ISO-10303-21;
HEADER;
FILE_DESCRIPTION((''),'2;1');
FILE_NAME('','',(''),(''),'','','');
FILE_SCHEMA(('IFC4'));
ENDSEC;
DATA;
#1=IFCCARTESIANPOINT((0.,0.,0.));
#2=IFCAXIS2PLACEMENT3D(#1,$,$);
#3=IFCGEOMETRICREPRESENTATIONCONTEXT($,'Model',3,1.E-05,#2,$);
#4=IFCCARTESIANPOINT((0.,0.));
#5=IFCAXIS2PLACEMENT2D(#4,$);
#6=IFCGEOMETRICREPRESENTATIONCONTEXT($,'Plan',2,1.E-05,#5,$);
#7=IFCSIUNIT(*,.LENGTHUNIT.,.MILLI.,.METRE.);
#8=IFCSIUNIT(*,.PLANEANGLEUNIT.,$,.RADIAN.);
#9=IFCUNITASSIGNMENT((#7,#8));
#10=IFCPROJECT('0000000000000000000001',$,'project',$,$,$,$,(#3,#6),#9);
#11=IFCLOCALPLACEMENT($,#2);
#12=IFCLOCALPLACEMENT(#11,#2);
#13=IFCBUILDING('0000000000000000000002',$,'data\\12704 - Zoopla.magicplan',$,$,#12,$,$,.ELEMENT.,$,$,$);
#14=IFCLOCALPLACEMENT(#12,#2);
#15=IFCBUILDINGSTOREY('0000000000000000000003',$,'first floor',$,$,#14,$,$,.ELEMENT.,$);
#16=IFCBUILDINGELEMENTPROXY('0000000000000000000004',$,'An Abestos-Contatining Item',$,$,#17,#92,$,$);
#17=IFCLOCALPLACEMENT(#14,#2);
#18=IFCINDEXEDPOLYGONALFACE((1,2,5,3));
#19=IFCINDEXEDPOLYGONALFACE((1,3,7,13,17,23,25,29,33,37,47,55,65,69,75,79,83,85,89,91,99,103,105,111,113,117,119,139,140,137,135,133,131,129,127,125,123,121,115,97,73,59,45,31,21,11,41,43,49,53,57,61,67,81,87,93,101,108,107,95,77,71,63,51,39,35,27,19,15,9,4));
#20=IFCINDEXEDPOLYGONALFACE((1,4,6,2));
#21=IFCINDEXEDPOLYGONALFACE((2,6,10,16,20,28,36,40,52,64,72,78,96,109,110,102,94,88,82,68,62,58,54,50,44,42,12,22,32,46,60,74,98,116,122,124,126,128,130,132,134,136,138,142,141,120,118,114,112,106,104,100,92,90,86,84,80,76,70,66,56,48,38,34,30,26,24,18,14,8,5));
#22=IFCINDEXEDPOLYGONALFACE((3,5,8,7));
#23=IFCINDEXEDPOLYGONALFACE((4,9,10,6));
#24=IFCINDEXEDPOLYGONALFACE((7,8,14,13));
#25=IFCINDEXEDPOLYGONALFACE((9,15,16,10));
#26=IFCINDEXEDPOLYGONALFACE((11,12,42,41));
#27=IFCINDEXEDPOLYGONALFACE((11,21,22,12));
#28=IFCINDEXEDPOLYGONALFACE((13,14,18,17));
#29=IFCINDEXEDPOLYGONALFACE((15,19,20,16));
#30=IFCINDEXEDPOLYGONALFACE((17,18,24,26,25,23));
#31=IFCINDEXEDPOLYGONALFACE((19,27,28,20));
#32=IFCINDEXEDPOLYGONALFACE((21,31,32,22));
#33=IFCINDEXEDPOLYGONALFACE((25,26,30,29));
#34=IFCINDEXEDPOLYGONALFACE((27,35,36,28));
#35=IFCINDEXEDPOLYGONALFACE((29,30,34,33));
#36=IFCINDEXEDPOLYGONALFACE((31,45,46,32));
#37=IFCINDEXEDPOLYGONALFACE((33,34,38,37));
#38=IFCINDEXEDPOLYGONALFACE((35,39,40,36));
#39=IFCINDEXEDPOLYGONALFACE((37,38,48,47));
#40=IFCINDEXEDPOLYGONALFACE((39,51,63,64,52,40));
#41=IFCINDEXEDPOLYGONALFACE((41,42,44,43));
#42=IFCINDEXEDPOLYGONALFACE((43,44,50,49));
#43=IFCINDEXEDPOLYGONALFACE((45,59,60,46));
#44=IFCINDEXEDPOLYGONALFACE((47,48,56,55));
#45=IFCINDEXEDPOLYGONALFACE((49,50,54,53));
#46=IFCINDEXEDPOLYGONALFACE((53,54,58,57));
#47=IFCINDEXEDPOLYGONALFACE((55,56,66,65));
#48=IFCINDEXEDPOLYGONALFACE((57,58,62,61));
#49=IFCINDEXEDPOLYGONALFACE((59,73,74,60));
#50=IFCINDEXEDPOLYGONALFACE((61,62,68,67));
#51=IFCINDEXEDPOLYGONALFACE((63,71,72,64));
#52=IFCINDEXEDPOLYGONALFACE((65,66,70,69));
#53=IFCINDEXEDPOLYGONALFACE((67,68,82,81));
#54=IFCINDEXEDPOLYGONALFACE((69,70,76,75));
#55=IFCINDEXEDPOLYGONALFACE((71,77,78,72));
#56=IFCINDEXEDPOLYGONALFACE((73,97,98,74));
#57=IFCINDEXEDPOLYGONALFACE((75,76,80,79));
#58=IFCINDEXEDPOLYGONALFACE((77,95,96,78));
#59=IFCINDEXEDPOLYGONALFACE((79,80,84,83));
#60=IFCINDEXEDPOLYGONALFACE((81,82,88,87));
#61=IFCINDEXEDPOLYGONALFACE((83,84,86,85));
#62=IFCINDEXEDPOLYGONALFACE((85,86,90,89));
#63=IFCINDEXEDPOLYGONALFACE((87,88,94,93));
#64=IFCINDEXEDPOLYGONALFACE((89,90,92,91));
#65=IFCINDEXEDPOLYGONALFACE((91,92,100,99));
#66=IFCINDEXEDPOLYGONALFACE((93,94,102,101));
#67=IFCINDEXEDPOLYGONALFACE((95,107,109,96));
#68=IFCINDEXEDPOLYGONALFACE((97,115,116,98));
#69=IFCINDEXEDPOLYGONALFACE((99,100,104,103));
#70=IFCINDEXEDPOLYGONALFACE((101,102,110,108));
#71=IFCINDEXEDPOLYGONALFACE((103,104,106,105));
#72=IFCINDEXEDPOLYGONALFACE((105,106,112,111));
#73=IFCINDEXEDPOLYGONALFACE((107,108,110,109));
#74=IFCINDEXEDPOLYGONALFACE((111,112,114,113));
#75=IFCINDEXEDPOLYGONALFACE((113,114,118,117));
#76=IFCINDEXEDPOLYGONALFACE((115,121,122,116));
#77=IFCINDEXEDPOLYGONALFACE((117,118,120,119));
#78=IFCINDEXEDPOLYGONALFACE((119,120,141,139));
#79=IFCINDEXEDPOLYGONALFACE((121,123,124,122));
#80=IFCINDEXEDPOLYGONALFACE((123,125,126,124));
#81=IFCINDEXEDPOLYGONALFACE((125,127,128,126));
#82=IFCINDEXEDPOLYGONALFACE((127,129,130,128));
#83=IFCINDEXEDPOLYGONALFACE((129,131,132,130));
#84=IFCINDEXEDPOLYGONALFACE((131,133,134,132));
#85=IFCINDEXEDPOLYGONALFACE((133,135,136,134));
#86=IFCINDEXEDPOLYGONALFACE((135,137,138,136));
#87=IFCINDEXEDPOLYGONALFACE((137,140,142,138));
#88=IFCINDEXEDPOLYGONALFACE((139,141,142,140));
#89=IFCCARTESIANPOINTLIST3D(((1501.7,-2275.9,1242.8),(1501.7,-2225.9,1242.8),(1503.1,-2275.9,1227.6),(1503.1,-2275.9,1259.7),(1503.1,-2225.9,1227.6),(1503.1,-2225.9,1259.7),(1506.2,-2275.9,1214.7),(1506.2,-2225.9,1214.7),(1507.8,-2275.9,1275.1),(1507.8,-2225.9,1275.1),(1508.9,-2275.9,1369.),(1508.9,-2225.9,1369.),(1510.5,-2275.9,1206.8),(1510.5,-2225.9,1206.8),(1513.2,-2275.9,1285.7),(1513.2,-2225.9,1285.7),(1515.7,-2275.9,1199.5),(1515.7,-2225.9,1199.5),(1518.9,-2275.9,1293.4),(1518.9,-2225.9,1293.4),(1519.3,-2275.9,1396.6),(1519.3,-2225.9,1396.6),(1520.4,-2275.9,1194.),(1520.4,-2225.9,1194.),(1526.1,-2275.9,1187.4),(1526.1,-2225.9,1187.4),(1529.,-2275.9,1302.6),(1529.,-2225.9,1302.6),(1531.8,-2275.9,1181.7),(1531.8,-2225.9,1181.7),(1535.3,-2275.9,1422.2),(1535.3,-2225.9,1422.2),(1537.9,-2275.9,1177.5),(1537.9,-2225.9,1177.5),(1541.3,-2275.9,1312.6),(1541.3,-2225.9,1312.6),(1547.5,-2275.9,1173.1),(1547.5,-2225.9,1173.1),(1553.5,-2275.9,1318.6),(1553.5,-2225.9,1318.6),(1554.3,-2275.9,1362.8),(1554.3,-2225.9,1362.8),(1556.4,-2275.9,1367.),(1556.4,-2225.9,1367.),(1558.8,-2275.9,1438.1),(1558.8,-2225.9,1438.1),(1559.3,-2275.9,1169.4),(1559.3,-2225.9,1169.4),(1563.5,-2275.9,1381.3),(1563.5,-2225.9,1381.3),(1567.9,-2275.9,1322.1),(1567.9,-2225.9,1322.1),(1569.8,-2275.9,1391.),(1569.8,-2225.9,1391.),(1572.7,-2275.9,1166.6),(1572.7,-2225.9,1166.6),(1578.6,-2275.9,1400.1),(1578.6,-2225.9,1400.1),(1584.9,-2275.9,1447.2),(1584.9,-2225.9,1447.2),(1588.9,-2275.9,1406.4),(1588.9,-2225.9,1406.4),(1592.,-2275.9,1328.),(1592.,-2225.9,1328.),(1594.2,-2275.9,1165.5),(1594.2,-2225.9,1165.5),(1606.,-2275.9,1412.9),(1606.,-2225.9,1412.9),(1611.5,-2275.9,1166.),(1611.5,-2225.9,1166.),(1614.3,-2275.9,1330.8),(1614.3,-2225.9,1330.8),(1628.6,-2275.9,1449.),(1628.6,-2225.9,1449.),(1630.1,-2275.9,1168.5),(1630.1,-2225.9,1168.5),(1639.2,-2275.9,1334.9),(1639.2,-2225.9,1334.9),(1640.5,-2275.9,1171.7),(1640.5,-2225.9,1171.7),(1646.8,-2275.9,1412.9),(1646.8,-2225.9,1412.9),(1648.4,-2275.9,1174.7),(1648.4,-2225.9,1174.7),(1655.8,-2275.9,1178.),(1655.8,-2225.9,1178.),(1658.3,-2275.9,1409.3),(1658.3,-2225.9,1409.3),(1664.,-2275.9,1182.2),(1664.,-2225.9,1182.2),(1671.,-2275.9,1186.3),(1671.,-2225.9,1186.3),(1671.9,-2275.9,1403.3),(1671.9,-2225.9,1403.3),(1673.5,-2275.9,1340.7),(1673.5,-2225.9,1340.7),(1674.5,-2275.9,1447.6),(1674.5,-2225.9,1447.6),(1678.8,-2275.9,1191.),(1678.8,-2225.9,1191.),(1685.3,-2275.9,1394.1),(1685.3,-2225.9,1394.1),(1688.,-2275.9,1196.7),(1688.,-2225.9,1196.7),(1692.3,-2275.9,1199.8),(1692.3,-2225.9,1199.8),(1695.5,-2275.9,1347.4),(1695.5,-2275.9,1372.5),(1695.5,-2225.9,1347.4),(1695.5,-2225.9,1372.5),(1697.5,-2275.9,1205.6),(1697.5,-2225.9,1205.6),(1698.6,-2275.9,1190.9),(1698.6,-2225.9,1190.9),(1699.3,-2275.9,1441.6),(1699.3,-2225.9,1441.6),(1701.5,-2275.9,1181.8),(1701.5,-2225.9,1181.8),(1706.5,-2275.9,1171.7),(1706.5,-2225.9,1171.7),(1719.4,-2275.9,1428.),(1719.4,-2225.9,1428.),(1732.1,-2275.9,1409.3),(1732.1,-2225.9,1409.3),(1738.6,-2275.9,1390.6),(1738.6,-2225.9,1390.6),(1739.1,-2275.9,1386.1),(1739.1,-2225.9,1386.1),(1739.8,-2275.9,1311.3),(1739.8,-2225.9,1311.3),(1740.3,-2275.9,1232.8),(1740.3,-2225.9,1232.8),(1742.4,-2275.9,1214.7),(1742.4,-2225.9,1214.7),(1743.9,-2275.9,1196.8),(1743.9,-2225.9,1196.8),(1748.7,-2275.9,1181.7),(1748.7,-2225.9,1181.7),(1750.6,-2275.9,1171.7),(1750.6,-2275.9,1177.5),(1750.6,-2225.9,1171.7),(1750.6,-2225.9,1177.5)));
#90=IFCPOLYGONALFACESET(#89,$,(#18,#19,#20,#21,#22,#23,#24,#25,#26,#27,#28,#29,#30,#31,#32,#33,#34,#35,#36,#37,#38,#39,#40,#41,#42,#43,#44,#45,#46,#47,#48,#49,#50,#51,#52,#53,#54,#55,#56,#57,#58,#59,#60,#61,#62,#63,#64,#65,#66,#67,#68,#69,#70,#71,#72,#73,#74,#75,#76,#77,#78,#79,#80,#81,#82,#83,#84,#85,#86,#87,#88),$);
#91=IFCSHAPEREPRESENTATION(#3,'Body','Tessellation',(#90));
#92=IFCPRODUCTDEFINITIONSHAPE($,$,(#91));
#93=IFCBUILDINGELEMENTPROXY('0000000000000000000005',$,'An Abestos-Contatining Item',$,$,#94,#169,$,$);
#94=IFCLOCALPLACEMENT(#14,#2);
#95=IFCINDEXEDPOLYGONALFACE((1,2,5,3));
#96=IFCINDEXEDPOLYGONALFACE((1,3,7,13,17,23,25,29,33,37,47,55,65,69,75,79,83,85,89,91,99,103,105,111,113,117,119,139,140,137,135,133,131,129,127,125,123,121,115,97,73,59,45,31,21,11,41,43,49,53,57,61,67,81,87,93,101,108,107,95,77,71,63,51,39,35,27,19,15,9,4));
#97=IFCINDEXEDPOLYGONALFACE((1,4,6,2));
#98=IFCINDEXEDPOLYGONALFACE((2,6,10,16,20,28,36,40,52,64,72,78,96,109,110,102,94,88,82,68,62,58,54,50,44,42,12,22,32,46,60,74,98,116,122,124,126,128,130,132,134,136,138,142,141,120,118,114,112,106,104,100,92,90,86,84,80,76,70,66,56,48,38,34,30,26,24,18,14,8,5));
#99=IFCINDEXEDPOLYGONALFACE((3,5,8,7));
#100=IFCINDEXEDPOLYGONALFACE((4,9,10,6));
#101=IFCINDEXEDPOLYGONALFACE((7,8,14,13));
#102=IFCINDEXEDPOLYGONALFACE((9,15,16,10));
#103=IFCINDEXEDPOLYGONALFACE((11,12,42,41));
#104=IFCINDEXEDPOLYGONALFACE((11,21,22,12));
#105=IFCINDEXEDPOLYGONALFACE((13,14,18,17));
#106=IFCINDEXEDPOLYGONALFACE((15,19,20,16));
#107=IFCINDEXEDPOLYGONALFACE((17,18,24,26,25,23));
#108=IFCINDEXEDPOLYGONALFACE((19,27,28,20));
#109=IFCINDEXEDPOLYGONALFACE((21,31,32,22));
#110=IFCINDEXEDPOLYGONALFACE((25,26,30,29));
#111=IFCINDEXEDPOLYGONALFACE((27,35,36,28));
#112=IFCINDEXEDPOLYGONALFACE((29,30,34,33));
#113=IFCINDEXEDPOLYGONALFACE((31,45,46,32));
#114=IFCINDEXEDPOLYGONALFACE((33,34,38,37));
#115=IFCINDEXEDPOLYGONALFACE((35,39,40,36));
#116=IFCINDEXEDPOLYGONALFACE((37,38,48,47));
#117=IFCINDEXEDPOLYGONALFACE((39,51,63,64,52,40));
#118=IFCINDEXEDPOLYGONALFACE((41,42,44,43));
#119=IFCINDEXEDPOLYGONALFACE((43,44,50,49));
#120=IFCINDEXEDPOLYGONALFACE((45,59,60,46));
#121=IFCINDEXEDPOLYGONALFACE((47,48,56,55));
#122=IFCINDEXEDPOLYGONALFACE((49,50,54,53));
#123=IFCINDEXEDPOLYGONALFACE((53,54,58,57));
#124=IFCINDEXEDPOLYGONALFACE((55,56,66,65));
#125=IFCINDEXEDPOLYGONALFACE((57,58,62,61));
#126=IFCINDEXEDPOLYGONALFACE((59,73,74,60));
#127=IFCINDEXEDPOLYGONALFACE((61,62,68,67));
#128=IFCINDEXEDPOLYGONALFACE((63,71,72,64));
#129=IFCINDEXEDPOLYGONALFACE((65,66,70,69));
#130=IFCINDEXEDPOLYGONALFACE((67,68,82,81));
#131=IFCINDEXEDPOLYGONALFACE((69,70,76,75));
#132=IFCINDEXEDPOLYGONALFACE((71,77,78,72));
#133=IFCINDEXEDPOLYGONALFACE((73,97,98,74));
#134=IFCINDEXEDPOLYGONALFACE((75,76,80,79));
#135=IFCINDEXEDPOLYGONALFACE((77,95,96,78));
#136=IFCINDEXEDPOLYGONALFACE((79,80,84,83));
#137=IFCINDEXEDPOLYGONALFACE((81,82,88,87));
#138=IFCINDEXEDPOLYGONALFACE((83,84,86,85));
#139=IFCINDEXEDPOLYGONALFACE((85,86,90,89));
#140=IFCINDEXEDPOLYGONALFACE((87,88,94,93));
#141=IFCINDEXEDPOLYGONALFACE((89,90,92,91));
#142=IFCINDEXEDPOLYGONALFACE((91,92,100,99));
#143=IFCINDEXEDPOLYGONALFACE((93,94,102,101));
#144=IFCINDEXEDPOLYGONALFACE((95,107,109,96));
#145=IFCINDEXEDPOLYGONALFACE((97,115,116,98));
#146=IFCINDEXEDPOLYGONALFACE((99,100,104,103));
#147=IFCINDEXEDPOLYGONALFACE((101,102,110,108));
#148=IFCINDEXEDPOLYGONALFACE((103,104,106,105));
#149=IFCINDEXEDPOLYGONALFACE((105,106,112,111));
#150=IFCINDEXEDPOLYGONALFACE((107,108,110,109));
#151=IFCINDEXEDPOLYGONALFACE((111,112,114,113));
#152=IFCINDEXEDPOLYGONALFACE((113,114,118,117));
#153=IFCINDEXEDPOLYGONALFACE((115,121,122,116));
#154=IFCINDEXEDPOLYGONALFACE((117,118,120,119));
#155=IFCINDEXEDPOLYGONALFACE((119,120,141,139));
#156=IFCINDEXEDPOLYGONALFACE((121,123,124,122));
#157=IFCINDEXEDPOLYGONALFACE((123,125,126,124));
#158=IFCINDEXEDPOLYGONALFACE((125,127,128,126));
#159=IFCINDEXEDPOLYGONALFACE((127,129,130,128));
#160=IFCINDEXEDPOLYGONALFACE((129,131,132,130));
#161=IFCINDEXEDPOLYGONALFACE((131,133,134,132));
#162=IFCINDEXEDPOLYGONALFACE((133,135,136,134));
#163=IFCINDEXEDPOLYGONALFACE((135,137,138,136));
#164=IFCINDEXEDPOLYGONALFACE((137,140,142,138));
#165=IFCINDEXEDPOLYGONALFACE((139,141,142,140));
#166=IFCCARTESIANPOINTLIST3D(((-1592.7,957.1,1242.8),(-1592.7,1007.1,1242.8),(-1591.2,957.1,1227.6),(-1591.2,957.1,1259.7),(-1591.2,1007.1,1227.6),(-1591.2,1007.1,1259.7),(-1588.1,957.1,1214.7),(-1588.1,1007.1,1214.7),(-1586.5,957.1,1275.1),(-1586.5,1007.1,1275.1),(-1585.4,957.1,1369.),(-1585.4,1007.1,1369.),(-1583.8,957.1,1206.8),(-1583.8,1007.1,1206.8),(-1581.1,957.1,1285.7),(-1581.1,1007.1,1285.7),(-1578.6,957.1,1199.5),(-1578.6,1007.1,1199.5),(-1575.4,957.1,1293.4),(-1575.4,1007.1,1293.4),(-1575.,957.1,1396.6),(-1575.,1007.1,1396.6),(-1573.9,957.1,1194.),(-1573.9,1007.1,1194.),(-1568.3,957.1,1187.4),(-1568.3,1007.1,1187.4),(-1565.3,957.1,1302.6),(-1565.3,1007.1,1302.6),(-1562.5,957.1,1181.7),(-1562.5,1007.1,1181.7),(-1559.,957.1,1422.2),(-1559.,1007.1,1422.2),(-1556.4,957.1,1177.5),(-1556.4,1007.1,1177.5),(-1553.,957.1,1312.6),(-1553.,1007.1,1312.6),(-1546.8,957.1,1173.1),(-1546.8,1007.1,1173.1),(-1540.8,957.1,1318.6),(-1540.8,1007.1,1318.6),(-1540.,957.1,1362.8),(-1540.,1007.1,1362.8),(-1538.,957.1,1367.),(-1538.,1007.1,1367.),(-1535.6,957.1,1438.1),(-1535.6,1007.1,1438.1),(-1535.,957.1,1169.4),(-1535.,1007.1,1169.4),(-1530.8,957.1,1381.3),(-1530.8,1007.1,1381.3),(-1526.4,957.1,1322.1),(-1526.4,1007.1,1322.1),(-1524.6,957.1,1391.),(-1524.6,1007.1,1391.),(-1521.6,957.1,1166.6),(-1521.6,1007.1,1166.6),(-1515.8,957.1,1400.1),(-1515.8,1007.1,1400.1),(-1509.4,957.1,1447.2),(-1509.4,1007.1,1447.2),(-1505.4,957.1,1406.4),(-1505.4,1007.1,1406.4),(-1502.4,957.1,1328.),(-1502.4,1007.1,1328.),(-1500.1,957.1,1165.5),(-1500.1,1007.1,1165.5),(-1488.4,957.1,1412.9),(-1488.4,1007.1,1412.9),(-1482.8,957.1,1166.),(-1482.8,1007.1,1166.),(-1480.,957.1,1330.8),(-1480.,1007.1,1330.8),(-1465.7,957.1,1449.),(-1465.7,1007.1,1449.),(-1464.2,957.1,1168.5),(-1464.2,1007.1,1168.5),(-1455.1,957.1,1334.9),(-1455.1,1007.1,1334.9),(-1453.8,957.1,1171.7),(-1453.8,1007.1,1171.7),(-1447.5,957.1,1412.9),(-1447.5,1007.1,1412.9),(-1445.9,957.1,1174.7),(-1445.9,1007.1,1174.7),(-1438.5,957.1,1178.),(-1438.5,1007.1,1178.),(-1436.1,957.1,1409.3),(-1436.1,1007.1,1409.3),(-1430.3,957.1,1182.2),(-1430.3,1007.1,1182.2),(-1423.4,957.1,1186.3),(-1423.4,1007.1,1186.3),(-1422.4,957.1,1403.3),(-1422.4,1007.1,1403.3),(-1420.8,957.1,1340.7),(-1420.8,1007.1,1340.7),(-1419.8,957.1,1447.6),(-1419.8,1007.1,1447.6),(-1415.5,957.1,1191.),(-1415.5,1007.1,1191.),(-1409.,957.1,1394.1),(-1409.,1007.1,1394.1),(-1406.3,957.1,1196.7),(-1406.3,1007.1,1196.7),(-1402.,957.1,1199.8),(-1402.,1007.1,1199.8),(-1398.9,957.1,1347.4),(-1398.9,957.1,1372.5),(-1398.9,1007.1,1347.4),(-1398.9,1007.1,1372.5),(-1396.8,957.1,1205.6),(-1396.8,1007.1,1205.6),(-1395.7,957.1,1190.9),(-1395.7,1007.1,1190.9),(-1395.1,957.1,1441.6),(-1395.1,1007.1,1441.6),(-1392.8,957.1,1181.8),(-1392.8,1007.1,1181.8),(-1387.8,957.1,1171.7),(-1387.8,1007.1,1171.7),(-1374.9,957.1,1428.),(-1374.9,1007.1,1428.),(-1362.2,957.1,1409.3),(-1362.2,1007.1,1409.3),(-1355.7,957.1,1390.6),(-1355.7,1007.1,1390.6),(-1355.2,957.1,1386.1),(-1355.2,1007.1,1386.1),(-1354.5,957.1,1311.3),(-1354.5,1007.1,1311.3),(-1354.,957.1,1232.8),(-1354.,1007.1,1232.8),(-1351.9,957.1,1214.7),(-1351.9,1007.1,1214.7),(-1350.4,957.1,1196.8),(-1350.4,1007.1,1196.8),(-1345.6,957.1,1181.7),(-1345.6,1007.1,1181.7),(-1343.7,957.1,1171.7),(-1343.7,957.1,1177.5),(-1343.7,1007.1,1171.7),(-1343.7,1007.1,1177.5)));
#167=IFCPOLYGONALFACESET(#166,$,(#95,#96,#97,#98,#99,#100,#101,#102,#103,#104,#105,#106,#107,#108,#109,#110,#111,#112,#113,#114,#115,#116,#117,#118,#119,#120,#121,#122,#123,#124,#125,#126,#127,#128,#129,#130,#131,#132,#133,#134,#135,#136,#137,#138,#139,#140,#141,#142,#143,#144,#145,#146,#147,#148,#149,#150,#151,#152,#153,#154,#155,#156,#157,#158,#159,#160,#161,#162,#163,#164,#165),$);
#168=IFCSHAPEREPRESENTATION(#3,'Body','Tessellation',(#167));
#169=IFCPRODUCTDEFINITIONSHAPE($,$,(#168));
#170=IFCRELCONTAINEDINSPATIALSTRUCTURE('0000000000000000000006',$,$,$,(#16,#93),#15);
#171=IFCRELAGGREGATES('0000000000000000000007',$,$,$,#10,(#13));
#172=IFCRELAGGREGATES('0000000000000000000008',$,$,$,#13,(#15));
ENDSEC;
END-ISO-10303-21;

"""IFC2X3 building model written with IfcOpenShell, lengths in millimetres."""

from ifc_helpers import new_model, si_unit, frame, origin, origin_2d, place, context, project, spatial, polyline, outline, extrude, element, save


model = new_model("IFC2X3")

# Units and contexts
model_context = context("Model", 3, precision=1e-05, world=origin())
plan_context = context("Plan", 2, precision=1e-05, world=origin_2d())
ifc_project = project(units=[si_unit("LENGTHUNIT", "METRE", prefix="MILLI"), si_unit("PLANEANGLEUNIT", "RADIAN")], contexts=[model_context, plan_context])

# Building, storey
placement_1 = place(None, origin())
building_placement = place(placement_1, origin())
building = spatial("IfcBuilding", under=ifc_project, at=building_placement, Name="data\\12704 - Zoopla.magicplan", CompositionType="ELEMENT")
storey_placement = place(building_placement, origin())
storey = spatial("IfcBuildingStorey", under=building, at=storey_placement, Name="first floor", CompositionType="ELEMENT")

# Building element proxies
placement_2 = place(None, frame((3984.0, 1316.8, 0.0)))
proxy_1_placement = place(placement_2, frame((-2483.4, -3542.6, 1165.0)))
element("IfcBuildingElementProxy", 1, at=proxy_1_placement, inside=storey, Name="An Abestos-Contatining Item", context=model_context, shape_type="SurfaceModel", body=[
    extrude(outline(polyline([(239.2, 0.0, 146.3), (239.7, 0.0, 67.8), (241.8, 0.0, 49.7), (243.3, 0.0, 31.9), (248.1, 0.0, 16.7), (250.0, 0.0, 12.5), (250.0, 0.0, 6.7), (205.8, 0.0, 6.7), (200.9, 0.0, 16.8), (197.9, 0.0, 25.9), (196.9, 0.0, 40.6), (191.6, 0.0, 34.8), (187.3, 0.0, 31.7), (178.2, 0.0, 26.0), (170.3, 0.0, 21.3), (163.4, 0.0, 17.2), (155.2, 0.0, 13.0), (147.8, 0.0, 9.7), (139.9, 0.0, 6.7), (129.5, 0.0, 3.5), (110.9, 0.0, 1.0), (93.6, 0.0, 0.5), (72.1, 0.0, 1.6), (58.6, 0.0, 4.4), (46.9, 0.0, 8.1), (37.3, 0.0, 12.5), (31.2, 0.0, 16.7), (25.4, 0.0, 22.4), (19.8, 0.0, 29.0), (15.1, 0.0, 34.5), (9.9, 0.0, 41.9), (5.5, 0.0, 49.7), (2.5, 0.0, 62.6), (1.0, 0.0, 77.8), (2.5, 0.0, 94.7), (7.2, 0.0, 110.1), (12.6, 0.0, 120.7), (18.2, 0.0, 128.4), (28.4, 0.0, 137.6), (40.7, 0.0, 147.6), (52.9, 0.0, 153.6), (67.3, 0.0, 157.1), (91.3, 0.0, 163.0), (113.7, 0.0, 165.8), (138.6, 0.0, 169.9), (172.9, 0.0, 175.7), (194.8, 0.0, 182.4), (194.8, 0.0, 207.5), (184.7, 0.0, 229.1), (171.3, 0.0, 238.3), (157.6, 0.0, 244.3), (146.2, 0.0, 247.9), (105.3, 0.0, 247.9), (88.3, 0.0, 241.4), (77.9, 0.0, 235.1), (69.1, 0.0, 226.0), (62.9, 0.0, 216.3), (55.7, 0.0, 202.0), (53.6, 0.0, 197.8), (8.2, 0.0, 204.0), (18.7, 0.0, 231.7), (34.6, 0.0, 257.2), (58.1, 0.0, 273.1), (84.2, 0.0, 282.2), (128.0, 0.0, 284.0), (173.9, 0.0, 282.6), (198.6, 0.0, 276.6), (218.8, 0.0, 263.1), (231.4, 0.0, 244.3), (238.0, 0.0, 225.6), (238.5, 0.0, 221.1)]), holes=[polyline([(193.0, 0.0, 144.2), (193.0, 0.0, 117.7), (190.5, 0.0, 97.8), (183.8, 0.0, 80.4), (174.2, 0.0, 64.5), (165.3, 0.0, 54.4), (152.5, 0.0, 47.3), (138.0, 0.0, 41.5), (124.6, 0.0, 37.8), (85.5, 0.0, 37.8), (75.0, 0.0, 41.4), (65.8, 0.0, 47.1), (57.8, 0.0, 55.4), (52.1, 0.0, 66.4), (49.5, 0.0, 74.4), (49.5, 0.0, 88.6), (55.3, 0.0, 100.7), (65.3, 0.0, 109.9), (81.0, 0.0, 119.8), (101.0, 0.0, 125.3), (119.9, 0.0, 128.5), (146.8, 0.0, 131.5), (165.0, 0.0, 134.9), (179.8, 0.0, 140.1), (193.0, 0.0, 144.2)])], kind="CURVE"), origin(), (0.0, -1.0, 0.0), 50.0),
])
placement_3 = place(None, frame((3984.0, 1316.8, 0.0)))
proxy_2_placement = place(placement_3, frame((-5577.7, -309.7, 1165.0)))
element("IfcBuildingElementProxy", 2, at=proxy_2_placement, inside=storey, Name="An Abestos-Contatining Item", context=model_context, shape_type="SurfaceModel", body=[
    extrude(outline(polyline([(239.2, 0.0, 146.3), (239.7, 0.0, 67.8), (241.8, 0.0, 49.7), (243.3, 0.0, 31.9), (248.1, 0.0, 16.7), (250.0, 0.0, 12.5), (250.0, 0.0, 6.7), (205.8, 0.0, 6.7), (200.9, 0.0, 16.8), (197.9, 0.0, 25.9), (196.9, 0.0, 40.6), (191.6, 0.0, 34.8), (187.3, 0.0, 31.7), (178.2, 0.0, 26.0), (170.3, 0.0, 21.3), (163.4, 0.0, 17.2), (155.2, 0.0, 13.0), (147.8, 0.0, 9.7), (139.9, 0.0, 6.7), (129.5, 0.0, 3.5), (110.9, 0.0, 1.0), (93.6, 0.0, 0.5), (72.1, 0.0, 1.6), (58.6, 0.0, 4.4), (46.9, 0.0, 8.1), (37.3, 0.0, 12.5), (31.2, 0.0, 16.7), (25.4, 0.0, 22.4), (19.8, 0.0, 29.0), (15.1, 0.0, 34.5), (9.9, 0.0, 41.9), (5.5, 0.0, 49.7), (2.5, 0.0, 62.6), (1.0, 0.0, 77.8), (2.5, 0.0, 94.7), (7.2, 0.0, 110.1), (12.6, 0.0, 120.7), (18.2, 0.0, 128.4), (28.4, 0.0, 137.6), (40.7, 0.0, 147.6), (52.9, 0.0, 153.6), (67.3, 0.0, 157.1), (91.3, 0.0, 163.0), (113.7, 0.0, 165.8), (138.6, 0.0, 169.9), (172.9, 0.0, 175.7), (194.8, 0.0, 182.4), (194.8, 0.0, 207.5), (184.7, 0.0, 229.1), (171.3, 0.0, 238.3), (157.6, 0.0, 244.3), (146.2, 0.0, 247.9), (105.3, 0.0, 247.9), (88.3, 0.0, 241.4), (77.9, 0.0, 235.1), (69.1, 0.0, 226.0), (62.9, 0.0, 216.3), (55.7, 0.0, 202.0), (53.6, 0.0, 197.8), (8.2, 0.0, 204.0), (18.7, 0.0, 231.7), (34.6, 0.0, 257.2), (58.1, 0.0, 273.1), (84.2, 0.0, 282.2), (128.0, 0.0, 284.0), (173.9, 0.0, 282.6), (198.6, 0.0, 276.6), (218.8, 0.0, 263.1), (231.4, 0.0, 244.3), (238.0, 0.0, 225.6), (238.5, 0.0, 221.1)]), holes=[polyline([(193.0, 0.0, 144.2), (193.0, 0.0, 117.7), (190.5, 0.0, 97.8), (183.8, 0.0, 80.4), (174.2, 0.0, 64.5), (165.3, 0.0, 54.4), (152.5, 0.0, 47.3), (138.0, 0.0, 41.5), (124.6, 0.0, 37.8), (85.5, 0.0, 37.8), (75.0, 0.0, 41.4), (65.8, 0.0, 47.1), (57.8, 0.0, 55.4), (52.1, 0.0, 66.4), (49.5, 0.0, 74.4), (49.5, 0.0, 88.6), (55.3, 0.0, 100.7), (65.3, 0.0, 109.9), (81.0, 0.0, 119.8), (101.0, 0.0, 125.3), (119.9, 0.0, 128.5), (146.8, 0.0, 131.5), (165.0, 0.0, 134.9), (179.8, 0.0, 140.1), (193.0, 0.0, 144.2)])], kind="CURVE"), origin(), (0.0, -1.0, 0.0), 50.0),
])

save(model, "model.ifc")
